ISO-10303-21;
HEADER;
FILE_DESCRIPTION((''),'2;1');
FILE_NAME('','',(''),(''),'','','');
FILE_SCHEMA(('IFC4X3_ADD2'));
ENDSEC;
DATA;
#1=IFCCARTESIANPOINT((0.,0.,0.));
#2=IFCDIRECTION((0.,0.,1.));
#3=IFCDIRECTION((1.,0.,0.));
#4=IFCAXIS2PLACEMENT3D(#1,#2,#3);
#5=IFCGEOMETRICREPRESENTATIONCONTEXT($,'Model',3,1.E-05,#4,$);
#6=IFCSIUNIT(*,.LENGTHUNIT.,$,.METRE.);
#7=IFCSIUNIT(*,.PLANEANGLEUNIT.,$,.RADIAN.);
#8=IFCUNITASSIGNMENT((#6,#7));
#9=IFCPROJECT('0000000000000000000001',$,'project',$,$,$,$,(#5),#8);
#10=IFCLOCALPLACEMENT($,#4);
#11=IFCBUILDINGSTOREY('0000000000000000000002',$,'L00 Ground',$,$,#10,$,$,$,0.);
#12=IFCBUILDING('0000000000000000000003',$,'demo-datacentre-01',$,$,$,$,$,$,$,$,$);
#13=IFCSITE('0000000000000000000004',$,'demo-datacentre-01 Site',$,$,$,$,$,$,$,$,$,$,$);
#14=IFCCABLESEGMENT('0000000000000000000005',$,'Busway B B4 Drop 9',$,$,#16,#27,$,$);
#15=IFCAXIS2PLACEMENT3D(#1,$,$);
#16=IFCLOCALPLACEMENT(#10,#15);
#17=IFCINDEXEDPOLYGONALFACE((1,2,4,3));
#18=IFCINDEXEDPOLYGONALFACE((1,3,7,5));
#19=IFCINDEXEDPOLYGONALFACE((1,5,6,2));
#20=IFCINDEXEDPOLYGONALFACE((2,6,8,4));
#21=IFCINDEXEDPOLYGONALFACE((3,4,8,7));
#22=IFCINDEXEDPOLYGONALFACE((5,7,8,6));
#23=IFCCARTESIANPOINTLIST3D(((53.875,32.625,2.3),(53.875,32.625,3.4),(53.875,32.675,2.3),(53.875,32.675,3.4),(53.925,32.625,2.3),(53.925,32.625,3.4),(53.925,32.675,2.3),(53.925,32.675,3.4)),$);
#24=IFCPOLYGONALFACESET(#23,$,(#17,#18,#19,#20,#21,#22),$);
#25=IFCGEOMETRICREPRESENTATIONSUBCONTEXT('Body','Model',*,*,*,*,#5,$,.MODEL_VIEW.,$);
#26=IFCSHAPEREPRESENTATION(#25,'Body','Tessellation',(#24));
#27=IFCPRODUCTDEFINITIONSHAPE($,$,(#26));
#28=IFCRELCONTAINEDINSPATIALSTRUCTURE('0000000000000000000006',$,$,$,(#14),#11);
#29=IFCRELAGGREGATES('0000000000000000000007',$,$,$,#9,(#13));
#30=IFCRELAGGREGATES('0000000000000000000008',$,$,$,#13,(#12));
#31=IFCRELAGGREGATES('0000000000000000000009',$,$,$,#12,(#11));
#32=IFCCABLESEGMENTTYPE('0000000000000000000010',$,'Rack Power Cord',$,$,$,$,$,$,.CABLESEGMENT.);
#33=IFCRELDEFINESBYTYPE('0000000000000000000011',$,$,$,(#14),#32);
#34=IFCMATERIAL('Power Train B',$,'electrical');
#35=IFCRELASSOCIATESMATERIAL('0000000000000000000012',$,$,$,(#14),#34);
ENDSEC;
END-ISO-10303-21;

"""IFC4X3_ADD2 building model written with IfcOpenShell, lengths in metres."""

from ifc_helpers import new_model, si_unit, frame, origin_with_axes, place, context, subcontext, project, spatial, rectangle, extrude, material, type_object, element, save


model = new_model("IFC4X3_ADD2")

# Units and contexts
model_context = context("Model", 3, precision=1e-05, world=origin_with_axes())
body_context = subcontext(model_context, "Body", "Model", "MODEL_VIEW")
ifc_project = project(units=[si_unit("LENGTHUNIT", "METRE"), si_unit("PLANEANGLEUNIT", "RADIAN")], contexts=[model_context])

# Site, building, storey
site = spatial("IfcSite", under=ifc_project, Name="demo-datacentre-01 Site")
building = spatial("IfcBuilding", under=site, Name="demo-datacentre-01")
storey_placement = place(None, origin_with_axes())
storey = spatial("IfcBuildingStorey", under=building, at=storey_placement, Name="L00 Ground", Elevation=0.0)

# Shared definitions
ifc_material_1 = material(Name="Power Train B", Category="electrical")

# Cable segment
cable_segment_type_1 = type_object("IfcCableSegmentType", Name="Rack Power Cord", PredefinedType="CABLESEGMENT")
for number, where, z_axis, x_axis, name in (
    (1, (53.9, 32.65, 3.4), (0.0, 0.0, -1.0), (1.0, 0.0, 0.0), "Busway B B4 Drop 9"),
):
    element("IfcCableSegment", number, at=place(storey_placement, frame(where, z_axis=z_axis, x_axis=x_axis)), inside=storey, type_object=cable_segment_type_1, material=ifc_material_1, Name=name, context=body_context, shape_type="SweptSolid", body=[
        extrude(rectangle(XDim=0.05, YDim=0.05), origin_with_axes(), (0.0, 0.0, 1.0), 1.1),
    ])

save(model, "model.ifc")
